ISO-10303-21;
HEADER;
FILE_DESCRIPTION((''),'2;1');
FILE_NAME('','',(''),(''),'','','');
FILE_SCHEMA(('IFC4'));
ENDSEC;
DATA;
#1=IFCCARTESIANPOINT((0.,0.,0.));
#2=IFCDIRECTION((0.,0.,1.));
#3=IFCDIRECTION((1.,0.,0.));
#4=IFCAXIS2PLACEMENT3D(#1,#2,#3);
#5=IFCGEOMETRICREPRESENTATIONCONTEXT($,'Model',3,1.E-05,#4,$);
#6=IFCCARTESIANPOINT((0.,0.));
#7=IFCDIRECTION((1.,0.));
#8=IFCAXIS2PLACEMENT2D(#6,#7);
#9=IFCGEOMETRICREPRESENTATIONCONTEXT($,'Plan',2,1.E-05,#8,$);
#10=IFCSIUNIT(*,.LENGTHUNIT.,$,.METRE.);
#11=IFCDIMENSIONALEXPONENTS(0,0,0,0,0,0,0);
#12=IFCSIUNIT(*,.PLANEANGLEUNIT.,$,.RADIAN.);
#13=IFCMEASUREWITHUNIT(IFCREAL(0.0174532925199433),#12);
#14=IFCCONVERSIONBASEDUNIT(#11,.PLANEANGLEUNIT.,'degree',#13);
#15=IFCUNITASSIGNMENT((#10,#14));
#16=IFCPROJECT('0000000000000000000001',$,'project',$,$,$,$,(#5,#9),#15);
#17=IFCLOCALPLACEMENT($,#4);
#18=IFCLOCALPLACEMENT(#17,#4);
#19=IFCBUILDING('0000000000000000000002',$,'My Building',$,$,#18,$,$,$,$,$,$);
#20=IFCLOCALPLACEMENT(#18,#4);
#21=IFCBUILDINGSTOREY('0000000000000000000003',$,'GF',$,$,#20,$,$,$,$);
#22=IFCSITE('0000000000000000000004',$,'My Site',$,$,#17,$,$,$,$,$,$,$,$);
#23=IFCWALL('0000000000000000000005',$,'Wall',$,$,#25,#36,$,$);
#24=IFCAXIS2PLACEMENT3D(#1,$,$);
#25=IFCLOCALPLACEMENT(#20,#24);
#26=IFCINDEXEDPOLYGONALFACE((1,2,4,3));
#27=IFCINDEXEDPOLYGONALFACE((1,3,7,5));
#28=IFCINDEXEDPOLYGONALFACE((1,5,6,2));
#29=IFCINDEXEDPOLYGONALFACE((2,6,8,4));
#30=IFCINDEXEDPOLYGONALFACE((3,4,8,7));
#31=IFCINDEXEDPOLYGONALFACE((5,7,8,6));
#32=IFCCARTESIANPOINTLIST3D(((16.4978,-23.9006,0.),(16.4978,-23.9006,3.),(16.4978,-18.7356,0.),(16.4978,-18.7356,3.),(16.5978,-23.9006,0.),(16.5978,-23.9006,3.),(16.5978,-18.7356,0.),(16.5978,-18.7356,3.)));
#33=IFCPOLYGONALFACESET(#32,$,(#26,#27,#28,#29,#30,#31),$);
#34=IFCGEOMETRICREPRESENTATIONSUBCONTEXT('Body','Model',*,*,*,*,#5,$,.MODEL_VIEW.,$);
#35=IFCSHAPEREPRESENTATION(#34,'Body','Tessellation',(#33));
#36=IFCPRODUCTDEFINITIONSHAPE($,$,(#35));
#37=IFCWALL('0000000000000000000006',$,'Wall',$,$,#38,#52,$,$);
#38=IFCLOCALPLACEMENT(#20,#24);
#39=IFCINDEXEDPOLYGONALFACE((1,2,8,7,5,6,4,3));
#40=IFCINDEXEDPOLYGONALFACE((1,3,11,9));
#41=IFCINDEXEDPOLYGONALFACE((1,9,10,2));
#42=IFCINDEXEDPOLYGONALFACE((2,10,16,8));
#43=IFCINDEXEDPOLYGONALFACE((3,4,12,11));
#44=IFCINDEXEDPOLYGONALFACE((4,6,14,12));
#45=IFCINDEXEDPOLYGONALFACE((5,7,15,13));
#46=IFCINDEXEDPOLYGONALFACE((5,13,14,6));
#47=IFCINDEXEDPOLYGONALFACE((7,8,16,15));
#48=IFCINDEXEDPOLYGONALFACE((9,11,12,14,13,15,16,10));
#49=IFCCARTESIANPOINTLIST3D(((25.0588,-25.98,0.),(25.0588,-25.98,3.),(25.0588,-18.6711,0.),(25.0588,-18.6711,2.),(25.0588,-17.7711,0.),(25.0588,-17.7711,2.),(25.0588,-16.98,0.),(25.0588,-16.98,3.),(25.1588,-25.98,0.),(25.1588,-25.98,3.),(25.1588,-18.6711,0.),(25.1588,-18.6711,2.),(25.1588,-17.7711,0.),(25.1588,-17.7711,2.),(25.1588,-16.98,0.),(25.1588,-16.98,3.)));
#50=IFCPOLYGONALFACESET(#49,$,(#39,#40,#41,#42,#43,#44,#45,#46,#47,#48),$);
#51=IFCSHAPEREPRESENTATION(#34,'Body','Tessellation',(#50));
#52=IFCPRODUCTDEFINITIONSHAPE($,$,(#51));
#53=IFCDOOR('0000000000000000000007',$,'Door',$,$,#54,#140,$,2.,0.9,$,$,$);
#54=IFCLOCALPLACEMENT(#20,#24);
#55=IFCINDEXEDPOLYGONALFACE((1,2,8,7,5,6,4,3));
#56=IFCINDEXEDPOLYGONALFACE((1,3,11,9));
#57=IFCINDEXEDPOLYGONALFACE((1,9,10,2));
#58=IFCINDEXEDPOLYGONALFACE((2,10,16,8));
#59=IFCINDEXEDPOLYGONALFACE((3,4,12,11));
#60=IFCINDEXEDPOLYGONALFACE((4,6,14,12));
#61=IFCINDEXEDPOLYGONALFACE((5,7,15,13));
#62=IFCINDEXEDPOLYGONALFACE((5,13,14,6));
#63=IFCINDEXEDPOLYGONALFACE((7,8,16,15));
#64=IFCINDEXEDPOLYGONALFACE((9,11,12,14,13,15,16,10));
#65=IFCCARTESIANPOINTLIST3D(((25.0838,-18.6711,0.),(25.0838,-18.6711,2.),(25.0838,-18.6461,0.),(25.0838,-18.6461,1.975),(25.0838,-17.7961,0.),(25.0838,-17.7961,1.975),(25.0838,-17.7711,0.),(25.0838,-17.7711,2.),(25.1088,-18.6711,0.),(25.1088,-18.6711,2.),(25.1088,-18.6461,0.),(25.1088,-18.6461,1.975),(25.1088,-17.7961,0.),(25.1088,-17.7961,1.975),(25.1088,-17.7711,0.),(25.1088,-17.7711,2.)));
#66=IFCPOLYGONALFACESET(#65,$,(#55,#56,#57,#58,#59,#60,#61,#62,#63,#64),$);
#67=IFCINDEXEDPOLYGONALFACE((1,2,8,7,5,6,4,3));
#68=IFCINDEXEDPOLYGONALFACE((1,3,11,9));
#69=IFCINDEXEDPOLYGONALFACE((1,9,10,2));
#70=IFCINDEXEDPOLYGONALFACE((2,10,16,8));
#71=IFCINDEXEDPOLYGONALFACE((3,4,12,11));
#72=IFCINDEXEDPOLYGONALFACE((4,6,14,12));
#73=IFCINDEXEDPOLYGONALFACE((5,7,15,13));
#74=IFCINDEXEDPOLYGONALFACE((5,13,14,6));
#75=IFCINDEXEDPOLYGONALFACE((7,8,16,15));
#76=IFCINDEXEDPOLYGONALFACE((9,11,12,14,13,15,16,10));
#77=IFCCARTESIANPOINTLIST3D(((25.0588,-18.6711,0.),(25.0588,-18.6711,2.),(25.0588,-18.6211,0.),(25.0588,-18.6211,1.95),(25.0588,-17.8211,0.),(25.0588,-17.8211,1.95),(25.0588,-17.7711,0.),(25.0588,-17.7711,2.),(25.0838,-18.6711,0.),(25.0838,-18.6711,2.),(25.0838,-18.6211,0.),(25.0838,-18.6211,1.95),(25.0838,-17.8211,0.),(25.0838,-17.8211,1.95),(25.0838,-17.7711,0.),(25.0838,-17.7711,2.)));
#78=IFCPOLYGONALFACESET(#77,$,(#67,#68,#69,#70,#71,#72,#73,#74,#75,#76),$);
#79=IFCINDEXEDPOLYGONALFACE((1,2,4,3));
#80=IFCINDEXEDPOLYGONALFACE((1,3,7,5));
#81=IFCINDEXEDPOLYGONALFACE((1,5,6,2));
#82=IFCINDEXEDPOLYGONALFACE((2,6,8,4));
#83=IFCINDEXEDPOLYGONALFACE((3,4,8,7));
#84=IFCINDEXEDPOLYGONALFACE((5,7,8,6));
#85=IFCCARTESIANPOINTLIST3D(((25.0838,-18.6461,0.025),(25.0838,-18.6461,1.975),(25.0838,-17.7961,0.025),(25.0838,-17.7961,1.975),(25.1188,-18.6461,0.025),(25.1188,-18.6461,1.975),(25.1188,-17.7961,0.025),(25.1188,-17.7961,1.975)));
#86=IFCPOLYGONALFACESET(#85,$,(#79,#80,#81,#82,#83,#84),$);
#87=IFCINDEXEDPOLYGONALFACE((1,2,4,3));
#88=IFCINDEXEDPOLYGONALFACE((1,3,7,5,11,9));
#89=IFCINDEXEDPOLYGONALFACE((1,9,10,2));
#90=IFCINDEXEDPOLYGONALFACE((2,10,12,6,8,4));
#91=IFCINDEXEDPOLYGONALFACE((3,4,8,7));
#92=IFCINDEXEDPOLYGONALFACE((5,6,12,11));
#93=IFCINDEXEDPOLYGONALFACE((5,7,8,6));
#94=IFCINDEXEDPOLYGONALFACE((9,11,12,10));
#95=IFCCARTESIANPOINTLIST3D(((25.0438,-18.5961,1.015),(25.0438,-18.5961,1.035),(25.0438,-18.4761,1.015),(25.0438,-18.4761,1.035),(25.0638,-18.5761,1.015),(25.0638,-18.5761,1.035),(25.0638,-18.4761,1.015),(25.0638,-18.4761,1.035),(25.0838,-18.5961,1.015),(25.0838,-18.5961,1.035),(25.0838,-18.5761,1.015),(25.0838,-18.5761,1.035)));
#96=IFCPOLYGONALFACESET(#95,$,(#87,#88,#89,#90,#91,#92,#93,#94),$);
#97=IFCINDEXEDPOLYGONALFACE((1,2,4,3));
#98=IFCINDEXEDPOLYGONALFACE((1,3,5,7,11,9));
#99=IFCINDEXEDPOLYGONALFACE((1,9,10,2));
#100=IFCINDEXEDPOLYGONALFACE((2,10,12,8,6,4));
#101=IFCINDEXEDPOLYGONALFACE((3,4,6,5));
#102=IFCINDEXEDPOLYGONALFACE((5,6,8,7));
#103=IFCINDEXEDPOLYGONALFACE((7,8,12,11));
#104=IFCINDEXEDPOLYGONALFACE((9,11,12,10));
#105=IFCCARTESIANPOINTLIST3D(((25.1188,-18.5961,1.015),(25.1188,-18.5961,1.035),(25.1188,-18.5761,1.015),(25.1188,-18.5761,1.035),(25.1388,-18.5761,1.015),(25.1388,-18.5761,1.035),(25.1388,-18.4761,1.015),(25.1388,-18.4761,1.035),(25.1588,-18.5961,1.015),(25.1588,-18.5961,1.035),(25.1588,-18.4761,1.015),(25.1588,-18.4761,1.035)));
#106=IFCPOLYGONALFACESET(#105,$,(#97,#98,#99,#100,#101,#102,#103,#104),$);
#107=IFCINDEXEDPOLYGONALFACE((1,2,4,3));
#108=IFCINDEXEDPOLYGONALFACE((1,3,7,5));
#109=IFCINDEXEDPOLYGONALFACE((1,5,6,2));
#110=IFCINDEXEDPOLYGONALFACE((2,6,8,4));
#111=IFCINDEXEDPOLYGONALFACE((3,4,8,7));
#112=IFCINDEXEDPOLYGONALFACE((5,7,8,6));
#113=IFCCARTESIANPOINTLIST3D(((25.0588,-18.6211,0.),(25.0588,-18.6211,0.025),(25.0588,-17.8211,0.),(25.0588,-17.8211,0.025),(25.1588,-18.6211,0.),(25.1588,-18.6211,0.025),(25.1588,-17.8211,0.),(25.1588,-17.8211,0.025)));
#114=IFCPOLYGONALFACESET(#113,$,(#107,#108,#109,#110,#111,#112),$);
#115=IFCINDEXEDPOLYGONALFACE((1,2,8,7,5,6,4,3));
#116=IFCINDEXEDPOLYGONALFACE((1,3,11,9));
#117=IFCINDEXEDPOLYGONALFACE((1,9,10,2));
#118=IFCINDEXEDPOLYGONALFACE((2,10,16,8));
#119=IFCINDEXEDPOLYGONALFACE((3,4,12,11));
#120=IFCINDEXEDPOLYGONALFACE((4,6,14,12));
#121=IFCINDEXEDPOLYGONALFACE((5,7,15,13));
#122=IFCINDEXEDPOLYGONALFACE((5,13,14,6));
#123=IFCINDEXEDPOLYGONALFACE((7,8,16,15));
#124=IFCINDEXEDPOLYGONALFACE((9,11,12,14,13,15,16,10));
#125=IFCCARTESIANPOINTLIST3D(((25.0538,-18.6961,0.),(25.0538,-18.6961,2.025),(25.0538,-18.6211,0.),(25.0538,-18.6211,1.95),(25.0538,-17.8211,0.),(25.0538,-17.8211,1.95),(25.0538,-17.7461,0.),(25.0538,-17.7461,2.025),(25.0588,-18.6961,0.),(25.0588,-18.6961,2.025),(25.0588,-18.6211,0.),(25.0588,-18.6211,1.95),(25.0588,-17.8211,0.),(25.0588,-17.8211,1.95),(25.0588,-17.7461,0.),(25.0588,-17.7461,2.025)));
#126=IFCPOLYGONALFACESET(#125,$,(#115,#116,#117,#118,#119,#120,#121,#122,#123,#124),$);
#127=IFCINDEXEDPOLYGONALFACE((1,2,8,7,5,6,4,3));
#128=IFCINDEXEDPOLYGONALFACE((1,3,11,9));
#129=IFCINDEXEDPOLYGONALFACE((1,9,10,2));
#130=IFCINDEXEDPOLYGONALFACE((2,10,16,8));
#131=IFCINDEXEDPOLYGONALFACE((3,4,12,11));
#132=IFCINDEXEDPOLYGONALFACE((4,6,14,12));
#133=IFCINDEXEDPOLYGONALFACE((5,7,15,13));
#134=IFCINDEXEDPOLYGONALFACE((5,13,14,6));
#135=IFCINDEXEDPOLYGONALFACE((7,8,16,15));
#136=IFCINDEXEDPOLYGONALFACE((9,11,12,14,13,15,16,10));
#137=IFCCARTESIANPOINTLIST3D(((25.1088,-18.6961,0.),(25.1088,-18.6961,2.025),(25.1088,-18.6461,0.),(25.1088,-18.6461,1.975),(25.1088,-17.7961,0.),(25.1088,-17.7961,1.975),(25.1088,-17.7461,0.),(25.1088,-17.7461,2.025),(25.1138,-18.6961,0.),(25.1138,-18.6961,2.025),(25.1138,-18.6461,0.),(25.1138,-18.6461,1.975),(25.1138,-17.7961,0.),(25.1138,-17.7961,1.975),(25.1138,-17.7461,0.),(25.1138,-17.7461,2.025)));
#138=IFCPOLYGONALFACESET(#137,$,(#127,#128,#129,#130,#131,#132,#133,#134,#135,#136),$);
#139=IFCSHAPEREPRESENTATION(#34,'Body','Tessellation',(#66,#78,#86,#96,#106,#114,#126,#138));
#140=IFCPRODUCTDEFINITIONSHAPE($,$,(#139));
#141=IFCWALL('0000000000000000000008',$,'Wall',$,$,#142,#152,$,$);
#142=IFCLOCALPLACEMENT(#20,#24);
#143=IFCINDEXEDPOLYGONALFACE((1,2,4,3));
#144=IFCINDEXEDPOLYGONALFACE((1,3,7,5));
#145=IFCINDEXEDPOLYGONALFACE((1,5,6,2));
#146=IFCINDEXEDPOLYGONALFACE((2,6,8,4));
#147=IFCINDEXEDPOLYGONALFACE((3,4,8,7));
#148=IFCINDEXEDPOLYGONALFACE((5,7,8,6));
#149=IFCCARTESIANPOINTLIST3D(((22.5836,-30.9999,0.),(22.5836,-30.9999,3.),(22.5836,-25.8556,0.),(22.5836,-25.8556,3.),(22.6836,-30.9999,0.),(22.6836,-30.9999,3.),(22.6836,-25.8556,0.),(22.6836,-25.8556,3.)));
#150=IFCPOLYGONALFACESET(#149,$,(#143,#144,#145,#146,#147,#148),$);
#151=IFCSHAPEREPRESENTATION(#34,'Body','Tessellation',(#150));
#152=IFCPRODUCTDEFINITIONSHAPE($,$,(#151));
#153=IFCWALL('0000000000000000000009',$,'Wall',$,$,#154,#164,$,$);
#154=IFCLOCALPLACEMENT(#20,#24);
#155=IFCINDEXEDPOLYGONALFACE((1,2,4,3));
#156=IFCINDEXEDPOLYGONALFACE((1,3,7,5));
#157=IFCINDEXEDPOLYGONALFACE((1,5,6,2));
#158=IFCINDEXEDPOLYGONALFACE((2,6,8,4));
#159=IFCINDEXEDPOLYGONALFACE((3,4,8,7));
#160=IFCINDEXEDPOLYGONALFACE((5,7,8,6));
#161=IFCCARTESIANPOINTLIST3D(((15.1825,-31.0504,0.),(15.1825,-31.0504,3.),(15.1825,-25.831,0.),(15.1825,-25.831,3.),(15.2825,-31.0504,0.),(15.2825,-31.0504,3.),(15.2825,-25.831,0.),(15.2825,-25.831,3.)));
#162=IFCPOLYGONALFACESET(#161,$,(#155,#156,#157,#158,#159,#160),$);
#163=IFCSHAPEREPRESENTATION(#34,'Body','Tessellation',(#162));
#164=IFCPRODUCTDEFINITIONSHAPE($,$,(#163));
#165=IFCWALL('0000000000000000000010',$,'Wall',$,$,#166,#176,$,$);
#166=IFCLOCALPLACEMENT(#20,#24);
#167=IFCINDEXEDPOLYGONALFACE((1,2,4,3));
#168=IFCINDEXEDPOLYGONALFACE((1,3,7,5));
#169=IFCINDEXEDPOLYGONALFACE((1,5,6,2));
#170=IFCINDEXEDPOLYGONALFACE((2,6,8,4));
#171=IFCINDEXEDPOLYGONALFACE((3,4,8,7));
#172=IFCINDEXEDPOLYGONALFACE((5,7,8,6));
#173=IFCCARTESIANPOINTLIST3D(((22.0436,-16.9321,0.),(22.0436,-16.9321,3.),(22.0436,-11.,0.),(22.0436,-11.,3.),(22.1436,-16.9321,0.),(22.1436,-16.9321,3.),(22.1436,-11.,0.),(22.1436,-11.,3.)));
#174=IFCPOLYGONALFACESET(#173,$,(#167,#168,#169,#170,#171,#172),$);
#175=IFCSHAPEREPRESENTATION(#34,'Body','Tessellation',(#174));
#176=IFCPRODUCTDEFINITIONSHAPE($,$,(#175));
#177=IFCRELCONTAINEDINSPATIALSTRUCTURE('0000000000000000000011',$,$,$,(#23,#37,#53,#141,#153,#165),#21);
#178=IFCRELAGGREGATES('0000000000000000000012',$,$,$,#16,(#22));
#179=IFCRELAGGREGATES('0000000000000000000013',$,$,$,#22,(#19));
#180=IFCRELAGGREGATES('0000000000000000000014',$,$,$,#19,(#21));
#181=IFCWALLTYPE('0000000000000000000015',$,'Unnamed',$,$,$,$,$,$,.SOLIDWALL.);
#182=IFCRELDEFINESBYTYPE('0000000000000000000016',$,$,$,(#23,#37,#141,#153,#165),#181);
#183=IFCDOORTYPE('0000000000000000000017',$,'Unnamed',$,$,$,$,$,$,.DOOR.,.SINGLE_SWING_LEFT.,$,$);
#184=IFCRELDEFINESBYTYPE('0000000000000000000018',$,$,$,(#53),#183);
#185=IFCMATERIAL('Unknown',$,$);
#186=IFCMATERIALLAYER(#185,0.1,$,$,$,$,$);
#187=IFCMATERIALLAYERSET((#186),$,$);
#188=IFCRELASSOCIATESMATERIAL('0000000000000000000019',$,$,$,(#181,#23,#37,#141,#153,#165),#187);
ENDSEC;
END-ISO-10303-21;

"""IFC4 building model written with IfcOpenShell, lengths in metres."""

from ifc_helpers import new_model, entity, si_unit, converted_unit, frame, origin_with_axes, origin_2d_with_axis, place, context, subcontext, project, spatial, line, indexed_curve, outline, extrude, shape, source, transform, mapped, material, layer, layer_set, layer_usage, type_object, type_shapes, element, fill, save


model = new_model("IFC4")

# Units and contexts
model_context = context("Model", 3, precision=1e-05, world=origin_with_axes())
plan_context = context("Plan", 2, precision=1e-05, world=origin_2d_with_axis())
body_context_1 = subcontext(model_context, "Body", "Model", "MODEL_VIEW")
body_context_2 = subcontext(plan_context, "Body", "Plan", "PLAN_VIEW")
ifc_project = project(units=[si_unit("LENGTHUNIT", "METRE"), converted_unit("PLANEANGLEUNIT", "degree", entity("IfcReal", 0.0174532925199433), si_unit("PLANEANGLEUNIT", "RADIAN"), dimensions=[0, 0, 0, 0, 0, 0, 0])], contexts=[model_context, plan_context])

# Site, building, storey
site_placement = place(None, origin_with_axes())
site = spatial("IfcSite", under=ifc_project, at=site_placement, Name="My Site")
building_placement = place(site_placement, origin_with_axes())
building = spatial("IfcBuilding", under=site, at=building_placement, Name="My Building")
storey_placement = place(building_placement, origin_with_axes())
storey = spatial("IfcBuildingStorey", under=building, at=storey_placement, Name="GF")

# Shared definitions
ifc_material = material(Name="Unknown")
ifc_layer = layer(ifc_material, 0.1)
ifc_layer_set = layer_set([ifc_layer])
wall_type = type_object("IfcWallType", Name="Unnamed", PredefinedType="SOLIDWALL", material=ifc_layer_set)

# Shared definitions
shared_shape_1 = source(origin_with_axes(), body_context_1, "Body", "SweptSolid", [
    extrude(outline(indexed_curve([(0.0, 0.0), (0.9, 0.0), (0.9, 2.0), (0.0, 2.0)], segments=[line(1, 2, 3, 4, 1)])), frame((0.0, -0.6, 0.0), z_axis=(0.0, -1.0, 0.0), x_axis=(1.0, 0.0, 0.0)), (0.0, 0.0, -1.0), 1.2),
])
door_type = type_object("IfcDoorType", Name="Unnamed", OperationType="SINGLE_SWING_LEFT", PredefinedType="DOOR")
shared_shape_2 = source(origin_with_axes(), body_context_1, "Body", "SweptSolid", [
    extrude(outline(indexed_curve([(0.0, 0.0), (0.0, 2.0), (0.9, 2.0), (0.9, 0.0), (0.875, 0.0), (0.875, 1.975), (0.025, 1.975), (0.025, 0.0)], segments=[line(1, 2, 3, 4, 5, 6, 7, 8, 1)])), frame((0.0, 0.025, 0.0), z_axis=(0.0, -1.0, 0.0), x_axis=(1.0, 0.0, 0.0)), (0.0, 0.0, -1.0), 0.025),
    extrude(outline(indexed_curve([(0.0, 0.0), (0.0, 2.0), (0.9, 2.0), (0.9, 0.0), (0.85, 0.0), (0.85, 1.95), (0.05, 1.95), (0.05, 0.0)], segments=[line(1, 2, 3, 4, 5, 6, 7, 8, 1)])), frame((0.0, 0.0, 0.0), z_axis=(0.0, -1.0, 0.0), x_axis=(1.0, 0.0, 0.0)), (0.0, 0.0, -1.0), 0.025),
    extrude(outline(indexed_curve([(0.0, 0.0), (0.85, 0.0), (0.85, 0.035), (0.0, 0.035)], segments=[line(1, 2, 3, 4, 1)])), frame((0.025, 0.025, 0.025), z_axis=(0.0, 0.0, 1.0), x_axis=(1.0, 0.0, 0.0)), (0.0, 0.0, 1.0), 1.95),
    extrude(outline(indexed_curve([(0.0, 0.0), (0.0, -0.04), (-0.12, -0.04), (-0.12, -0.02), (-0.02, -0.02), (-0.02, 0.0)], segments=[line(1, 2, 3, 4, 5, 6, 1)])), frame((0.825, 0.025, 1.015), z_axis=(0.0, 0.0, 1.0), x_axis=(1.0, 0.0, 0.0)), (0.0, 0.0, 1.0), 0.02),
    extrude(outline(indexed_curve([(0.0, 0.0), (0.0, 0.04), (-0.12, 0.04), (-0.12, 0.02), (-0.02, 0.02), (-0.02, 0.0)], segments=[line(1, 2, 3, 4, 5, 6, 1)])), frame((0.825, 0.06, 1.015), z_axis=(0.0, 0.0, 1.0), x_axis=(1.0, 0.0, 0.0)), (0.0, 0.0, 1.0), 0.02),
    extrude(outline(indexed_curve([(0.0, 0.0), (0.8, 0.0), (0.8, 0.1), (0.0, 0.1)], segments=[line(1, 2, 3, 4, 1)])), frame((0.05, 0.0, 0.0), z_axis=(0.0, 0.0, 1.0), x_axis=(1.0, 0.0, 0.0)), (0.0, 0.0, 1.0), 0.025),
    extrude(outline(indexed_curve([(0.0, 0.0), (0.0, 2.025), (0.95, 2.025), (0.95, 0.0), (0.875, 0.0), (0.875, 1.95), (0.075, 1.95), (0.075, 0.0)], segments=[line(1, 2, 3, 4, 5, 6, 7, 8, 1)])), frame((-0.025, -0.005, 0.0), z_axis=(0.0, -1.0, 0.0), x_axis=(1.0, 0.0, 0.0)), (0.0, 0.0, -1.0), 0.005),
    extrude(outline(indexed_curve([(0.0, 0.0), (0.0, 2.025), (0.95, 2.025), (0.95, 0.0), (0.9, 0.0), (0.9, 1.975), (0.05, 1.975), (0.05, 0.0)], segments=[line(1, 2, 3, 4, 5, 6, 7, 8, 1)])), frame((-0.025, 0.05, 0.0), z_axis=(0.0, -1.0, 0.0), x_axis=(1.0, 0.0, 0.0)), (0.0, 0.0, -1.0), 0.005),
])
shared_shape_3 = source(origin_with_axes(), body_context_2, "Body", "Curve2D", [
    entity("IfcIndexedPolyCurve", entity("IfcCartesianPointList2D", [[0.0, 0.0], [0.0, 0.05], [0.025, 0.05], [0.025, 0.025], [0.05, 0.025], [0.05, 0.0]]), [entity("IfcLineIndex", [1, 2, 3, 4, 5, 6, 1])]),
    entity("IfcIndexedPolyCurve", entity("IfcCartesianPointList2D", [[0.9, 0.0], [0.9, 0.05], [0.875, 0.05], [0.875, 0.025], [0.85, 0.025], [0.85, 0.0]]), [entity("IfcLineIndex", [1, 2, 3, 4, 5, 6, 1])]),
    entity("IfcTrimmedCurve", entity("IfcEllipse", entity("IfcAxis2Placement2D", entity("IfcCartesianPoint", [0.06, 0.05]), entity("IfcDirection", [1.0, 0.0])), 0.815, 0.85), [entity("IfcCartesianPoint", [0.875, 0.05])], [entity("IfcCartesianPoint", [0.06, 0.9])], True, "CARTESIAN"),
    entity("IfcIndexedPolyCurve", entity("IfcCartesianPointList2D", [[0.025, 0.05], [0.06, 0.05], [0.06, 0.9], [0.025, 0.9]]), [entity("IfcLineIndex", [1, 2, 3, 4, 1])]),
])
type_shapes(door_type, [shared_shape_2, shared_shape_3])

# Wall
ifc_layer_usage_1 = layer_usage(ifc_layer_set, "AXIS2", "POSITIVE", 0.0)
wall_1_placement = place(storey_placement, frame((16.4978, -18.7356, 0.0), z_axis=(0.0, 0.0, 1.0), x_axis=(0.0, -1.0, 0.0)))
element("IfcWall", 1, at=wall_1_placement, inside=storey, type_object=wall_type, material=ifc_layer_usage_1, Name="Wall", context=body_context_1, shape_type="SweptSolid", body=[
    extrude(outline(indexed_curve([(0.0, 0.0), (0.0, 0.1), (5.1651, 0.1), (5.1651, 0.0)], segments=[line(1, 2, 3, 4, 1)])), origin_with_axes(), (0.0, 0.0, 1.0), 3.0),
])

# Wall, opening, door
ifc_layer_usage_2 = layer_usage(ifc_layer_set, "AXIS2", "POSITIVE", 0.0)
wall_2_placement = place(storey_placement, frame((25.0588, -16.98, 0.0), z_axis=(0.0, 0.0, 1.0), x_axis=(0.0, -1.0, 0.0)))
wall_2 = element("IfcWall", 2, at=wall_2_placement, inside=storey, type_object=wall_type, material=ifc_layer_usage_2, Name="Wall", context=body_context_1, shape_type="SweptSolid", body=[
    extrude(outline(indexed_curve([(0.0, 0.0), (0.0, 0.1), (9.0, 0.1), (9.0, 0.0)], segments=[line(1, 2, 3, 4, 1)])), origin_with_axes(), (0.0, 0.0, 1.0), 3.0),
])
opening_1_placement = place(wall_2_placement, frame((0.7911, 0.0, 0.0), z_axis=(0.0, 0.0, 1.0), x_axis=(1.0, 0.0, 0.0)))
opening_1 = element("IfcOpeningElement", 3, at=opening_1_placement, cuts=wall_2, PredefinedType="OPENING", context=body_context_1, shape_type="MappedRepresentation", body=[
    mapped(shared_shape_1, transform((0.0, 0.0, 0.0), x_axis=(1.0, 0.0, 0.0), y_axis=(0.0, 1.0, 0.0), z_axis=(0.0, 0.0, 1.0), scale=1.0)),
])
door_1_placement = place(opening_1_placement, frame((0.0, 0.0, 0.0), z_axis=(0.0, 0.0, 1.0), x_axis=(1.0, 0.0, 0.0)))
door_1 = element("IfcDoor", 4, at=door_1_placement, inside=storey, type_object=door_type, Name="Door", OverallHeight=2.0, OverallWidth=0.9, shapes=[
    shape(body_context_1, "Body", "MappedRepresentation", [mapped(shared_shape_2, transform((0.0, 0.0, 0.0), x_axis=(1.0, 0.0, 0.0), y_axis=(0.0, 1.0, 0.0), z_axis=(0.0, 0.0, 1.0), scale=1.0))]),
    shape(body_context_2, "Body", "MappedRepresentation", [mapped(shared_shape_3, transform((0.0, 0.0, 0.0), x_axis=(1.0, 0.0, 0.0), y_axis=(0.0, 1.0, 0.0), z_axis=(0.0, 0.0, 1.0), scale=1.0))]),
])
fill(opening_1, door_1)

# Walls
ifc_layer_usage_3 = layer_usage(ifc_layer_set, "AXIS2", "POSITIVE", 0.0)
wall_3_placement = place(storey_placement, frame((22.5836, -25.8556, 0.0), z_axis=(0.0, 0.0, 1.0), x_axis=(0.0, -1.0, 0.0)))
element("IfcWall", 5, at=wall_3_placement, inside=storey, type_object=wall_type, material=ifc_layer_usage_3, Name="Wall", context=body_context_1, shape_type="SweptSolid", body=[
    extrude(outline(indexed_curve([(0.0, 0.0), (0.0, 0.1), (5.1443, 0.1), (5.1443, 0.0)], segments=[line(1, 2, 3, 4, 1)])), origin_with_axes(), (0.0, 0.0, 1.0), 3.0),
])
ifc_layer_usage_4 = layer_usage(ifc_layer_set, "AXIS2", "POSITIVE", 0.0)
wall_4_placement = place(storey_placement, frame((15.1825, -25.831, 0.0), z_axis=(0.0, 0.0, 1.0), x_axis=(0.0, -1.0, 0.0)))
element("IfcWall", 6, at=wall_4_placement, inside=storey, type_object=wall_type, material=ifc_layer_usage_4, Name="Wall", context=body_context_1, shape_type="SweptSolid", body=[
    extrude(outline(indexed_curve([(0.0, 0.0), (0.0, 0.1), (5.2194, 0.1), (5.2194, 0.0)], segments=[line(1, 2, 3, 4, 1)])), origin_with_axes(), (0.0, 0.0, 1.0), 3.0),
])
ifc_layer_usage_5 = layer_usage(ifc_layer_set, "AXIS2", "POSITIVE", 0.0)
wall_5_placement = place(storey_placement, frame((22.0436, -11.0, 0.0), z_axis=(0.0, 0.0, 1.0), x_axis=(0.0, -1.0, 0.0)))
element("IfcWall", 7, at=wall_5_placement, inside=storey, type_object=wall_type, material=ifc_layer_usage_5, Name="Wall", context=body_context_1, shape_type="SweptSolid", body=[
    extrude(outline(indexed_curve([(0.0, 0.0), (0.0, 0.1), (5.9321, 0.1), (5.9321, 0.0)], segments=[line(1, 2, 3, 4, 1)])), origin_with_axes(), (0.0, 0.0, 1.0), 3.0),
])

save(model, "model.ifc")
